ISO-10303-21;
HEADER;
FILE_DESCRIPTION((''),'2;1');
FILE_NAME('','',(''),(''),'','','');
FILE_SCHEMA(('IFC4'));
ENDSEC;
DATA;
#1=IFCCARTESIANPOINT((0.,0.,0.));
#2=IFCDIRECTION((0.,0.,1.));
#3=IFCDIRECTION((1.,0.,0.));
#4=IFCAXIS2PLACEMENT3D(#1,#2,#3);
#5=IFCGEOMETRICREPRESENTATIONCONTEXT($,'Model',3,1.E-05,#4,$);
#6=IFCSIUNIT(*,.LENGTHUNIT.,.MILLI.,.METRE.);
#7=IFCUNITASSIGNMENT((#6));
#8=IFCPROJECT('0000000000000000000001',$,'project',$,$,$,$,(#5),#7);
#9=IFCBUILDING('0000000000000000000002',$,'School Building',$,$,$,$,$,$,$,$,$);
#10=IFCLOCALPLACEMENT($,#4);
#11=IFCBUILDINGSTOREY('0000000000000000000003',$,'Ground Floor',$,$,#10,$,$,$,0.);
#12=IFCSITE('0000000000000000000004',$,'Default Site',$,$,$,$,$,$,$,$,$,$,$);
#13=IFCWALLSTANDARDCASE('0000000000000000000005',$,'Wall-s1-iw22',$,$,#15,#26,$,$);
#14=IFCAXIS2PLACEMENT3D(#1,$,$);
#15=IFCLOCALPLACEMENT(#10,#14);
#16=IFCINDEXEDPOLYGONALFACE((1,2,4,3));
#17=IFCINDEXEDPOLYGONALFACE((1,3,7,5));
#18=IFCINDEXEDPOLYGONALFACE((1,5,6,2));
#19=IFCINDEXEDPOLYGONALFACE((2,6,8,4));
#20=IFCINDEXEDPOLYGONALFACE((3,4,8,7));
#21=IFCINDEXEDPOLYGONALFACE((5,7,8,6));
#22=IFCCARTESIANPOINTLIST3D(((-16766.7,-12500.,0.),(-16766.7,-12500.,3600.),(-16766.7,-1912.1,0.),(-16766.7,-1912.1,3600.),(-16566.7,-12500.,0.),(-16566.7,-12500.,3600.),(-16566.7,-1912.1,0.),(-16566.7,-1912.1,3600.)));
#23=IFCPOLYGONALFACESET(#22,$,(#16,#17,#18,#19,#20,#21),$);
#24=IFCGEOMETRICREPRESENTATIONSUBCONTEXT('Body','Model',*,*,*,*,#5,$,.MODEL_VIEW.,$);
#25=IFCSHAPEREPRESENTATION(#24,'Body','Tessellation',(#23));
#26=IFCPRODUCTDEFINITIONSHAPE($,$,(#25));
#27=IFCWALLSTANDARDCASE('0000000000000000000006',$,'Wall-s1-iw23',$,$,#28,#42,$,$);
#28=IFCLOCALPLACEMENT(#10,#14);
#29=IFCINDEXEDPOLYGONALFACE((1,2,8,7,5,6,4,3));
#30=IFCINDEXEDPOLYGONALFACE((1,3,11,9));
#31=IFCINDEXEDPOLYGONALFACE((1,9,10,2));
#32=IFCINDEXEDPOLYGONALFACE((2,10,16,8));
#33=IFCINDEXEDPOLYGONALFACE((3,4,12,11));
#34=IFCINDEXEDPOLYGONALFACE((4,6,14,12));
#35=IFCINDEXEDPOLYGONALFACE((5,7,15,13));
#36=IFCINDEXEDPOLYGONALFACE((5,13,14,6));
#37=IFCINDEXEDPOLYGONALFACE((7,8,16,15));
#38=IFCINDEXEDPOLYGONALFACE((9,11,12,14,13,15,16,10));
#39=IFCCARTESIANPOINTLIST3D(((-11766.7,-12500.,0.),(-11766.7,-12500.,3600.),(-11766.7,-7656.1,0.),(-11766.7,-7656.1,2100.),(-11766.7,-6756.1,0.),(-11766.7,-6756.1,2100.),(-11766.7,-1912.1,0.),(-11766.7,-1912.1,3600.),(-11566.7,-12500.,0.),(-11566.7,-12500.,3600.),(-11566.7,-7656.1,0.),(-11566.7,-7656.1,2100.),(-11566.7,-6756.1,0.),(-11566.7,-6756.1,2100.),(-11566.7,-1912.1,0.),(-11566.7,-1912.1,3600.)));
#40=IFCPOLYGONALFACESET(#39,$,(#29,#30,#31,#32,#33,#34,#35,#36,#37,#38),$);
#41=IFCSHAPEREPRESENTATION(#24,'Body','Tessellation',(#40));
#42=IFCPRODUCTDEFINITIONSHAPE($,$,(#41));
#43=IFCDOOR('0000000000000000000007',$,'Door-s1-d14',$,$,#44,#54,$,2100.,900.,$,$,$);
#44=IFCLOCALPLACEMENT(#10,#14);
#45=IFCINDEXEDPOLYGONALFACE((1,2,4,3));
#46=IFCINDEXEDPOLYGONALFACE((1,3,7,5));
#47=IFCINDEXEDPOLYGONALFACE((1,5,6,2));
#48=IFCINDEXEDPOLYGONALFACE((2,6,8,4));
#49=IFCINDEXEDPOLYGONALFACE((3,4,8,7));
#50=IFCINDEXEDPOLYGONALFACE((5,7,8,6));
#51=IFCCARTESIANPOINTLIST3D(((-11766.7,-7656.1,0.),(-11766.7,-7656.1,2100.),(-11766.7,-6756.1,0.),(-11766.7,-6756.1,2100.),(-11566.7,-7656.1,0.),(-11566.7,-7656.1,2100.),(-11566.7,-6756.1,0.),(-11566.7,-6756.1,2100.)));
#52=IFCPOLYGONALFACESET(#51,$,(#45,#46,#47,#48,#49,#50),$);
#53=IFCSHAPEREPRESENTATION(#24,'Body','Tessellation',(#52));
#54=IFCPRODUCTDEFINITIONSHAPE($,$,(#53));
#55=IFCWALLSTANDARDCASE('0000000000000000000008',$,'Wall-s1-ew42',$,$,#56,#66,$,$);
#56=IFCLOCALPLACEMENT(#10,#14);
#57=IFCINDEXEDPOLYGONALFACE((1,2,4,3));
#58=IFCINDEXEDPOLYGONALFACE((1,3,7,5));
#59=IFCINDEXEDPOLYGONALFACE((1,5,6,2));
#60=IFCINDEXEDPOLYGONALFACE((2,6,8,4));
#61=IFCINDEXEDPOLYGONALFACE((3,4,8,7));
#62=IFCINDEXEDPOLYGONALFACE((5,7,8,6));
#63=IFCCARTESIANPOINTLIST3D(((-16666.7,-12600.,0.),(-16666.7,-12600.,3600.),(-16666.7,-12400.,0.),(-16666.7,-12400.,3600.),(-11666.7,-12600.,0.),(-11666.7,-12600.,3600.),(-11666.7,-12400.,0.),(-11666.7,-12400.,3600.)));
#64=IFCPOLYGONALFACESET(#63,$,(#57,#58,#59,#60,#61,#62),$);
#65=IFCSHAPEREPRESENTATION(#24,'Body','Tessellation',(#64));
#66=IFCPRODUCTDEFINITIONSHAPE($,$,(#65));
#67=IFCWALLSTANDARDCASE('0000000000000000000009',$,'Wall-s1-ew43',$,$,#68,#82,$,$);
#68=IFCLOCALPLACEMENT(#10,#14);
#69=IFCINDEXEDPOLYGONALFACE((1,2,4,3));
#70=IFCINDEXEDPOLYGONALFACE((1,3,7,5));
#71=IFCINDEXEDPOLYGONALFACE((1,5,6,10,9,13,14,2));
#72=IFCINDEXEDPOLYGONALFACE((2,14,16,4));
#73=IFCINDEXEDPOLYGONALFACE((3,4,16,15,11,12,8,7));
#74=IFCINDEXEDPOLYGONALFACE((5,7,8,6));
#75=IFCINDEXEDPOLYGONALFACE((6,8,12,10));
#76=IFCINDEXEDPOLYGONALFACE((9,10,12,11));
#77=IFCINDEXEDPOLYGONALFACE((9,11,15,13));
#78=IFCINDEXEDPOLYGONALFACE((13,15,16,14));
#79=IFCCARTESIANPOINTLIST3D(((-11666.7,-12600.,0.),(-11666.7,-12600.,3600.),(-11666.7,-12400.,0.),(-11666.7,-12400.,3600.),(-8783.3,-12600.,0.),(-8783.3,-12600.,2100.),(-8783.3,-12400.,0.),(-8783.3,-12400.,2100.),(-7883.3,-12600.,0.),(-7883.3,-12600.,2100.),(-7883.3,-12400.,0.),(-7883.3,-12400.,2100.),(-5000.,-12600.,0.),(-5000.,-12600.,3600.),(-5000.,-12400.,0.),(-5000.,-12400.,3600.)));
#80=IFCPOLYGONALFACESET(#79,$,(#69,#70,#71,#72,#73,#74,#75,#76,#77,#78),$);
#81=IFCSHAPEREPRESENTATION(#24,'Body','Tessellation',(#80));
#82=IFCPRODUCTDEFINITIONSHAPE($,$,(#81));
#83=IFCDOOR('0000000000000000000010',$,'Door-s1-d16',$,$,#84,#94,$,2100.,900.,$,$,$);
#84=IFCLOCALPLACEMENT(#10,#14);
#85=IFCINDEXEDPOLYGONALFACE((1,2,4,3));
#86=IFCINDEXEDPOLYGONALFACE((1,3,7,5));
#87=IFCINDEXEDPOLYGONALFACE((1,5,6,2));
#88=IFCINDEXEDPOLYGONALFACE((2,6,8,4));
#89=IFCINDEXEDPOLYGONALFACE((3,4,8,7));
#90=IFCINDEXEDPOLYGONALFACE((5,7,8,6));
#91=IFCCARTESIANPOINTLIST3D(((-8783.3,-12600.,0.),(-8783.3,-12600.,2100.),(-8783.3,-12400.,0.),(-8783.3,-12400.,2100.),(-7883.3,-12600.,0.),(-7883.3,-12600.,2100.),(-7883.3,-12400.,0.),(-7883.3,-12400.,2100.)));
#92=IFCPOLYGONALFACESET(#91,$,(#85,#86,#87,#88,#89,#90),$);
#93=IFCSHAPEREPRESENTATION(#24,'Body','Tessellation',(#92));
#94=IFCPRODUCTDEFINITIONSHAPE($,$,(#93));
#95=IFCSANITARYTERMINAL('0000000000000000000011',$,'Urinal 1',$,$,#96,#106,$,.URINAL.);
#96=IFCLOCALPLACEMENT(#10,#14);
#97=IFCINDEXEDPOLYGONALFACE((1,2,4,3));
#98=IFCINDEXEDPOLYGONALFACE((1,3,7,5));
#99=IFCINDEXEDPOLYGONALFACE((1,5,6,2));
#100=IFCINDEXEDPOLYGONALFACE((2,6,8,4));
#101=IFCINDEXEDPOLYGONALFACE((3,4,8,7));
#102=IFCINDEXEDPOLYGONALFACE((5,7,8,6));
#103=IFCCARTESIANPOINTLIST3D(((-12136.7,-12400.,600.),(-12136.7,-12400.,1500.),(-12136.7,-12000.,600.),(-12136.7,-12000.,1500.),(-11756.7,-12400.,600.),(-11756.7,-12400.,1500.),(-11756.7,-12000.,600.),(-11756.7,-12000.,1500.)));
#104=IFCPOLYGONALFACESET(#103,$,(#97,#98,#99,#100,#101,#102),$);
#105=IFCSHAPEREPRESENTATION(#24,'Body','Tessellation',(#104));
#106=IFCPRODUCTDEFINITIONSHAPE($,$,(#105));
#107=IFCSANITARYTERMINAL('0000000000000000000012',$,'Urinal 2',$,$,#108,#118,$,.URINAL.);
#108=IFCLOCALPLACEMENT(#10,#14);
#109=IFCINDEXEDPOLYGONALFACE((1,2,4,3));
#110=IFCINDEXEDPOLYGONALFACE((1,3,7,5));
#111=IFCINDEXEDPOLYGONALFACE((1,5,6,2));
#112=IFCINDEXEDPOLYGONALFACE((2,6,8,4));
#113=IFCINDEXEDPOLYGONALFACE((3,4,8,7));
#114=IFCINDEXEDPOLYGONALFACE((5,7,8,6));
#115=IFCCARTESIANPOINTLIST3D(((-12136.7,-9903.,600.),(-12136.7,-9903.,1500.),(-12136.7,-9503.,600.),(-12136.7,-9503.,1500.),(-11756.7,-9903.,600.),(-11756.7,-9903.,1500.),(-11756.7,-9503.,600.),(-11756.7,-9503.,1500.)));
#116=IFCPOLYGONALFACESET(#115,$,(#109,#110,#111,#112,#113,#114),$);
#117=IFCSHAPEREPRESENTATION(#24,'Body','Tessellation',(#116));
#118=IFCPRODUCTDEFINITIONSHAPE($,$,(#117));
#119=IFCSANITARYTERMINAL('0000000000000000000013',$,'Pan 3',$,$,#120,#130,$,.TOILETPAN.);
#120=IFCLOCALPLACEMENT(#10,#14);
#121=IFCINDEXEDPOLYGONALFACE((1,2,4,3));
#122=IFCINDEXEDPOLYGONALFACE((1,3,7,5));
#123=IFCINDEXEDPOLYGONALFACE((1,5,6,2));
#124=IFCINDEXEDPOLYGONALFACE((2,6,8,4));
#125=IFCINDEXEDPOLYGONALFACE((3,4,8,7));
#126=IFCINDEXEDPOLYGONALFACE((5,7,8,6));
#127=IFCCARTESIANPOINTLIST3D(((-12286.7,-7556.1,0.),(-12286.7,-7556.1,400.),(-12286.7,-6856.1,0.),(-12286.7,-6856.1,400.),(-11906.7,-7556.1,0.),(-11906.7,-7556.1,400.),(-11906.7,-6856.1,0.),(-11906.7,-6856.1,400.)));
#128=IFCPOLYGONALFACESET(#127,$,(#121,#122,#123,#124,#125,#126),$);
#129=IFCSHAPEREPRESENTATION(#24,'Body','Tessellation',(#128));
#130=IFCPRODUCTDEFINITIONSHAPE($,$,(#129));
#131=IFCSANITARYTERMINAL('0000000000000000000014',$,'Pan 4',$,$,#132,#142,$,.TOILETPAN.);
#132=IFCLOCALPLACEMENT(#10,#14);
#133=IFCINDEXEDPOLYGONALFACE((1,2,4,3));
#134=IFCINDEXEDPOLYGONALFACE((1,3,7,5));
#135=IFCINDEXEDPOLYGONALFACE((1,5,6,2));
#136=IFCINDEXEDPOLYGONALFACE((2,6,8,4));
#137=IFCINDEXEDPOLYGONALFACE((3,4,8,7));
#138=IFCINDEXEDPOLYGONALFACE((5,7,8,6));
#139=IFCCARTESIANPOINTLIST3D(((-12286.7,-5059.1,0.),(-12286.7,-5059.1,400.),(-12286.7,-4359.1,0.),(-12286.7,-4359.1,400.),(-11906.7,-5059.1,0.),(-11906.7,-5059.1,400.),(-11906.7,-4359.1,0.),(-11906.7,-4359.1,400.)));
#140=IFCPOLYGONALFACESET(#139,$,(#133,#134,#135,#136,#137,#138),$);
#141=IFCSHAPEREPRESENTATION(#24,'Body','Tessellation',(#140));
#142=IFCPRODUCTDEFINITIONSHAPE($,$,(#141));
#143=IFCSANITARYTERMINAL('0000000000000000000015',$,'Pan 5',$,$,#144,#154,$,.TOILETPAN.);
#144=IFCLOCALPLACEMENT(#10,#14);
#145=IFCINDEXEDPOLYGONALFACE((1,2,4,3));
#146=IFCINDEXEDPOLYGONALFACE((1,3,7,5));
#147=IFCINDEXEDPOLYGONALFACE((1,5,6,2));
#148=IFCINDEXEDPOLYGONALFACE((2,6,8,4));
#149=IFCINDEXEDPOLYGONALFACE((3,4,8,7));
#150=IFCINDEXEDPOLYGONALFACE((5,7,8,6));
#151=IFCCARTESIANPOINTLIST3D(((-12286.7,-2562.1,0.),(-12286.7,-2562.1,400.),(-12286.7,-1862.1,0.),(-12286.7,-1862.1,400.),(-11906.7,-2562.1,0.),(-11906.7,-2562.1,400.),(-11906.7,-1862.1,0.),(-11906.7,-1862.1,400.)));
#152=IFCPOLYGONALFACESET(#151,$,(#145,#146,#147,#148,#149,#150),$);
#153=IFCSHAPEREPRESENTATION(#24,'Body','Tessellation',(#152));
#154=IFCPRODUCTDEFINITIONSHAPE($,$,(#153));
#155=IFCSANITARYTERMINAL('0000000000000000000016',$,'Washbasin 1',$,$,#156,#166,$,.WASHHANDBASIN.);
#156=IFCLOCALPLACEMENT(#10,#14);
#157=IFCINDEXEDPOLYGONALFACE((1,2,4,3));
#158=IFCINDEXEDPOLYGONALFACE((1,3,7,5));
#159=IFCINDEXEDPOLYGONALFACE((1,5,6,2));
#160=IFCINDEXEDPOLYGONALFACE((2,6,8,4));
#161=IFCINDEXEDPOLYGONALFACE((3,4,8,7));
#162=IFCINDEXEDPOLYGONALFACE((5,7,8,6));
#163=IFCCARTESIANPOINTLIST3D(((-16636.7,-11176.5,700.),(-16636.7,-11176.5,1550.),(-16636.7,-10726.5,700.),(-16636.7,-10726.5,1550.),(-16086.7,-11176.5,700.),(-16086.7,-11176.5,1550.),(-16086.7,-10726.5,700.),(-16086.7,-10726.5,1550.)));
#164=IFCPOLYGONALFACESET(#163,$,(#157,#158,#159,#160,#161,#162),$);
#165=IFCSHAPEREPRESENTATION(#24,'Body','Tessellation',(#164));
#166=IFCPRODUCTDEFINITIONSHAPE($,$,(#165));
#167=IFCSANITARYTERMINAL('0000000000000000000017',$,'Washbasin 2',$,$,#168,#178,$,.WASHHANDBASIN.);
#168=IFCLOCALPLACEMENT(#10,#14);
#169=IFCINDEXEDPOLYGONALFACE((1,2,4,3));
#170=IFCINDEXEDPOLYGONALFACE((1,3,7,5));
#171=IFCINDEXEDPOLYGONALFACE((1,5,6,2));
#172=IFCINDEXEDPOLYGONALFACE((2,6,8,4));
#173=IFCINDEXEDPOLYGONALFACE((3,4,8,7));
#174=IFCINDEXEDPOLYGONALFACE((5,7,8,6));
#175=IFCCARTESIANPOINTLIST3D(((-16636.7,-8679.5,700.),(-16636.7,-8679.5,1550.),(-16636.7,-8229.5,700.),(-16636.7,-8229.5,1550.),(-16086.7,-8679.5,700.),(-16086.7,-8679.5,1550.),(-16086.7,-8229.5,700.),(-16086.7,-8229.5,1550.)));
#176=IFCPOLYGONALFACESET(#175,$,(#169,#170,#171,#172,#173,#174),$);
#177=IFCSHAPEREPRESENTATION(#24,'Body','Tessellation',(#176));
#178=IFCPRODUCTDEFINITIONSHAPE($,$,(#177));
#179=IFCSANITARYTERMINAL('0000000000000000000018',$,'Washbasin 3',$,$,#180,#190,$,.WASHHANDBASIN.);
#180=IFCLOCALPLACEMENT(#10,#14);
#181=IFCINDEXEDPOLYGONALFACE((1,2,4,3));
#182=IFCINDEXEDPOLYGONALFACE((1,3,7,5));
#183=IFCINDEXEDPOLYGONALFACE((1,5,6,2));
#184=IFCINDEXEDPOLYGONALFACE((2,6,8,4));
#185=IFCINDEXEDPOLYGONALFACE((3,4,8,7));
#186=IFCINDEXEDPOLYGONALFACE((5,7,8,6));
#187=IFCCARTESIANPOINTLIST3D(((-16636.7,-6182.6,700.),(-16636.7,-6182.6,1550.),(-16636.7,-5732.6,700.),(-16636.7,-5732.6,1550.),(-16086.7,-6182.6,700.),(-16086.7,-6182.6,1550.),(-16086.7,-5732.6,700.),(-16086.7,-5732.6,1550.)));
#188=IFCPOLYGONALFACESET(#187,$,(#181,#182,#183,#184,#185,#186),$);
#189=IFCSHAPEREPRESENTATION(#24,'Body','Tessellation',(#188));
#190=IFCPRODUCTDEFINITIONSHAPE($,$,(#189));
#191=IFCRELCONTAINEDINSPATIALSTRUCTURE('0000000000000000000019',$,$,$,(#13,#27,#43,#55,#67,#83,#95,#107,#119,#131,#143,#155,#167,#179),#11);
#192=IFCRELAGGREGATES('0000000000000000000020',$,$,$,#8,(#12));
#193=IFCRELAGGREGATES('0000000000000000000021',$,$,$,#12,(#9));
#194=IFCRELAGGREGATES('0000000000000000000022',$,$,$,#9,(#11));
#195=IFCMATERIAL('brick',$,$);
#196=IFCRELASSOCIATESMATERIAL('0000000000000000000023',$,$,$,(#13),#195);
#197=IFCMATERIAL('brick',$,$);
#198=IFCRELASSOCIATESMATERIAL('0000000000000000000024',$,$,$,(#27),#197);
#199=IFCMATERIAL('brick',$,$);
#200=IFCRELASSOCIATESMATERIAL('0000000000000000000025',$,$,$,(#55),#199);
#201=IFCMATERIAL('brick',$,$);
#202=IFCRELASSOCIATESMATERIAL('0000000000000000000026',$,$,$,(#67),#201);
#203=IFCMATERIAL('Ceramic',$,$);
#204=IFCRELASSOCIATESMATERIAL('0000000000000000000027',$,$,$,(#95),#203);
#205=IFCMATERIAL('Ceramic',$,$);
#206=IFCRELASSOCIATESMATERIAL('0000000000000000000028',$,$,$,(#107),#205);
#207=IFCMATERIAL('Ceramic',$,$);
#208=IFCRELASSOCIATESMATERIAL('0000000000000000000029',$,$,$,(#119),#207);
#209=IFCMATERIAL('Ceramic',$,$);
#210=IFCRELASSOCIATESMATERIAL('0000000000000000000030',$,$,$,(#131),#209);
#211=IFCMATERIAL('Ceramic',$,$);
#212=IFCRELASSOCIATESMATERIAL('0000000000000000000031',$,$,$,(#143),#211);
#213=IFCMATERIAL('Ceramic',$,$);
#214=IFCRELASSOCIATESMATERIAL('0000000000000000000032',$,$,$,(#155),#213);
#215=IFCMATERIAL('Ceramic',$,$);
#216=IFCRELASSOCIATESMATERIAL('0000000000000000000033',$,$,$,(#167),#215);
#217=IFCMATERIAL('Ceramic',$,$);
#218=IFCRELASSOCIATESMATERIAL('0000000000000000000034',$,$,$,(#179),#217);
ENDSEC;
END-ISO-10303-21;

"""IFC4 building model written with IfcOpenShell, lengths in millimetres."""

from ifc_helpers import new_model, si_unit, frame, frame_2d, origin_with_axes, origin_2d, place, context, subcontext, project, spatial, rectangle, extrude, material, element, fill, save


model = new_model("IFC4")

# Units and contexts
model_context = context("Model", 3, precision=1e-05, world=origin_with_axes())
body_context = subcontext(model_context, "Body", "Model", "MODEL_VIEW")
ifc_project = project(units=[si_unit("LENGTHUNIT", "METRE", prefix="MILLI")], contexts=[model_context])

# Site, building, storey
site = spatial("IfcSite", under=ifc_project, Name="Default Site")
building = spatial("IfcBuilding", under=site, Name="School Building")
storey_placement = place(None, origin_with_axes())
storey = spatial("IfcBuildingStorey", under=building, at=storey_placement, Name="Ground Floor", Elevation=0.0)

# Wall
ifc_material_1 = material(Name="brick")
wall_1_placement = place(storey_placement, frame((-16666.7, -12500.0, 0.0), z_axis=(0.0, 0.0, 1.0), x_axis=(0.0, 1.0, 0.0)))
element("IfcWallStandardCase", 1, at=wall_1_placement, inside=storey, material=ifc_material_1, Name="Wall-s1-iw22", context=body_context, shape_type="SweptSolid", body=[
    extrude(rectangle(XDim=10587.9, YDim=200.0, at=frame_2d((5293.9, 0.0))), origin_with_axes(), (0.0, 0.0, 1.0), 3600.0),
])

# Wall, opening, door
ifc_material_2 = material(Name="brick")
wall_2_placement = place(storey_placement, frame((-11666.7, -12500.0, 0.0), z_axis=(0.0, 0.0, 1.0), x_axis=(0.0, 1.0, 0.0)))
wall_2 = element("IfcWallStandardCase", 2, at=wall_2_placement, inside=storey, material=ifc_material_2, Name="Wall-s1-iw23", context=body_context, shape_type="SweptSolid", body=[
    extrude(rectangle(XDim=10587.9, YDim=200.0, at=frame_2d((5293.9, 0.0))), origin_with_axes(), (0.0, 0.0, 1.0), 3600.0),
])
opening_1_placement = place(wall_2_placement, frame((4843.9, 0.0, 0.0), z_axis=(0.0, 0.0, 1.0), x_axis=(1.0, 0.0, 0.0)))
opening_1 = element("IfcOpeningElement", 3, at=opening_1_placement, cuts=wall_2, context=body_context, shape_type="SweptSolid", body=[
    extrude(rectangle(XDim=900.0, YDim=400.0, at=frame_2d((450.0, 0.0))), origin_with_axes(), (0.0, 0.0, 1.0), 2100.0),
])
door_1_placement = place(storey_placement, frame((-11666.7, -7656.1, 0.0), z_axis=(0.0, 0.0, 1.0), x_axis=(0.0, 1.0, 0.0)))
door_1 = element("IfcDoor", 4, at=door_1_placement, inside=storey, Name="Door-s1-d14", OverallHeight=2100.0, OverallWidth=900.0, context=body_context, shape_type="SweptSolid", body=[
    extrude(rectangle(XDim=900.0, YDim=200.0, at=frame_2d((450.0, 0.0))), origin_with_axes(), (0.0, 0.0, 1.0), 2100.0),
])
fill(opening_1, door_1)

# Wall
ifc_material_3 = material(Name="brick")
wall_3_placement = place(storey_placement, frame((-16666.7, -12500.0, 0.0), z_axis=(0.0, 0.0, 1.0), x_axis=(1.0, 0.0, 0.0)))
element("IfcWallStandardCase", 5, at=wall_3_placement, inside=storey, material=ifc_material_3, Name="Wall-s1-ew42", context=body_context, shape_type="SweptSolid", body=[
    extrude(rectangle(XDim=5000.0, YDim=200.0, at=frame_2d((2500.0, 0.0))), origin_with_axes(), (0.0, 0.0, 1.0), 3600.0),
])

# Wall, opening, door
ifc_material_4 = material(Name="brick")
wall_4_placement = place(storey_placement, frame((-11666.7, -12500.0, 0.0), z_axis=(0.0, 0.0, 1.0), x_axis=(1.0, 0.0, 0.0)))
wall_4 = element("IfcWallStandardCase", 6, at=wall_4_placement, inside=storey, material=ifc_material_4, Name="Wall-s1-ew43", context=body_context, shape_type="SweptSolid", body=[
    extrude(rectangle(XDim=6666.7, YDim=200.0, at=frame_2d((3333.3, 0.0))), origin_with_axes(), (0.0, 0.0, 1.0), 3600.0),
])
opening_2_placement = place(wall_4_placement, frame((2883.3, 0.0, 0.0), z_axis=(0.0, 0.0, 1.0), x_axis=(1.0, 0.0, 0.0)))
opening_2 = element("IfcOpeningElement", 7, at=opening_2_placement, cuts=wall_4, context=body_context, shape_type="SweptSolid", body=[
    extrude(rectangle(XDim=900.0, YDim=400.0, at=frame_2d((450.0, 0.0))), origin_with_axes(), (0.0, 0.0, 1.0), 2100.0),
])
door_2_placement = place(storey_placement, frame((-8783.3, -12500.0, 0.0), z_axis=(0.0, 0.0, 1.0), x_axis=(1.0, 0.0, 0.0)))
door_2 = element("IfcDoor", 8, at=door_2_placement, inside=storey, Name="Door-s1-d16", OverallHeight=2100.0, OverallWidth=900.0, context=body_context, shape_type="SweptSolid", body=[
    extrude(rectangle(XDim=900.0, YDim=200.0, at=frame_2d((450.0, 0.0))), origin_with_axes(), (0.0, 0.0, 1.0), 2100.0),
])
fill(opening_2, door_2)

# Sanitary terminals
ifc_material_5 = material(Name="Ceramic")
sanitary_terminal_1_placement = place(storey_placement, frame((-11946.7, -12200.0, 600.0), z_axis=(0.0, 0.0, 1.0), x_axis=(0.0, 1.0, 0.0)))
element("IfcSanitaryTerminal", 9, at=sanitary_terminal_1_placement, inside=storey, material=ifc_material_5, Name="Urinal 1", PredefinedType="URINAL", context=body_context, shape_type="SweptSolid", body=[
    extrude(rectangle(XDim=400.0, YDim=380.0, at=origin_2d()), origin_with_axes(), (0.0, 0.0, 1.0), 900.0),
])
ifc_material_6 = material(Name="Ceramic")
sanitary_terminal_2_placement = place(storey_placement, frame((-11946.7, -9703.0, 600.0), z_axis=(0.0, 0.0, 1.0), x_axis=(0.0, 1.0, 0.0)))
element("IfcSanitaryTerminal", 10, at=sanitary_terminal_2_placement, inside=storey, material=ifc_material_6, Name="Urinal 2", PredefinedType="URINAL", context=body_context, shape_type="SweptSolid", body=[
    extrude(rectangle(XDim=400.0, YDim=380.0, at=origin_2d()), origin_with_axes(), (0.0, 0.0, 1.0), 900.0),
])
ifc_material_7 = material(Name="Ceramic")
sanitary_terminal_3_placement = place(storey_placement, frame((-12096.7, -7206.1, 0.0), z_axis=(0.0, 0.0, 1.0), x_axis=(0.0, 1.0, 0.0)))
element("IfcSanitaryTerminal", 11, at=sanitary_terminal_3_placement, inside=storey, material=ifc_material_7, Name="Pan 3", PredefinedType="TOILETPAN", context=body_context, shape_type="SweptSolid", body=[
    extrude(rectangle(XDim=700.0, YDim=380.0, at=origin_2d()), origin_with_axes(), (0.0, 0.0, 1.0), 400.0),
])
ifc_material_8 = material(Name="Ceramic")
sanitary_terminal_4_placement = place(storey_placement, frame((-12096.7, -4709.1, 0.0), z_axis=(0.0, 0.0, 1.0), x_axis=(0.0, 1.0, 0.0)))
element("IfcSanitaryTerminal", 12, at=sanitary_terminal_4_placement, inside=storey, material=ifc_material_8, Name="Pan 4", PredefinedType="TOILETPAN", context=body_context, shape_type="SweptSolid", body=[
    extrude(rectangle(XDim=700.0, YDim=380.0, at=origin_2d()), origin_with_axes(), (0.0, 0.0, 1.0), 400.0),
])
ifc_material_9 = material(Name="Ceramic")
sanitary_terminal_5_placement = place(storey_placement, frame((-12096.7, -2212.1, 0.0), z_axis=(0.0, 0.0, 1.0), x_axis=(0.0, 1.0, 0.0)))
element("IfcSanitaryTerminal", 13, at=sanitary_terminal_5_placement, inside=storey, material=ifc_material_9, Name="Pan 5", PredefinedType="TOILETPAN", context=body_context, shape_type="SweptSolid", body=[
    extrude(rectangle(XDim=700.0, YDim=380.0, at=origin_2d()), origin_with_axes(), (0.0, 0.0, 1.0), 400.0),
])
ifc_material_10 = material(Name="Ceramic")
sanitary_terminal_6_placement = place(storey_placement, frame((-16361.7, -10951.5, 700.0), z_axis=(0.0, 0.0, 1.0), x_axis=(0.0, 1.0, 0.0)))
element("IfcSanitaryTerminal", 14, at=sanitary_terminal_6_placement, inside=storey, material=ifc_material_10, Name="Washbasin 1", PredefinedType="WASHHANDBASIN", context=body_context, shape_type="SweptSolid", body=[
    extrude(rectangle(XDim=450.0, YDim=550.0, at=origin_2d()), origin_with_axes(), (0.0, 0.0, 1.0), 850.0),
])
ifc_material_11 = material(Name="Ceramic")
sanitary_terminal_7_placement = place(storey_placement, frame((-16361.7, -8454.5, 700.0), z_axis=(0.0, 0.0, 1.0), x_axis=(0.0, 1.0, 0.0)))
element("IfcSanitaryTerminal", 15, at=sanitary_terminal_7_placement, inside=storey, material=ifc_material_11, Name="Washbasin 2", PredefinedType="WASHHANDBASIN", context=body_context, shape_type="SweptSolid", body=[
    extrude(rectangle(XDim=450.0, YDim=550.0, at=origin_2d()), origin_with_axes(), (0.0, 0.0, 1.0), 850.0),
])
ifc_material_12 = material(Name="Ceramic")
sanitary_terminal_8_placement = place(storey_placement, frame((-16361.7, -5957.6, 700.0), z_axis=(0.0, 0.0, 1.0), x_axis=(0.0, 1.0, 0.0)))
element("IfcSanitaryTerminal", 16, at=sanitary_terminal_8_placement, inside=storey, material=ifc_material_12, Name="Washbasin 3", PredefinedType="WASHHANDBASIN", context=body_context, shape_type="SweptSolid", body=[
    extrude(rectangle(XDim=450.0, YDim=550.0, at=origin_2d()), origin_with_axes(), (0.0, 0.0, 1.0), 850.0),
])

save(model, "model.ifc")
